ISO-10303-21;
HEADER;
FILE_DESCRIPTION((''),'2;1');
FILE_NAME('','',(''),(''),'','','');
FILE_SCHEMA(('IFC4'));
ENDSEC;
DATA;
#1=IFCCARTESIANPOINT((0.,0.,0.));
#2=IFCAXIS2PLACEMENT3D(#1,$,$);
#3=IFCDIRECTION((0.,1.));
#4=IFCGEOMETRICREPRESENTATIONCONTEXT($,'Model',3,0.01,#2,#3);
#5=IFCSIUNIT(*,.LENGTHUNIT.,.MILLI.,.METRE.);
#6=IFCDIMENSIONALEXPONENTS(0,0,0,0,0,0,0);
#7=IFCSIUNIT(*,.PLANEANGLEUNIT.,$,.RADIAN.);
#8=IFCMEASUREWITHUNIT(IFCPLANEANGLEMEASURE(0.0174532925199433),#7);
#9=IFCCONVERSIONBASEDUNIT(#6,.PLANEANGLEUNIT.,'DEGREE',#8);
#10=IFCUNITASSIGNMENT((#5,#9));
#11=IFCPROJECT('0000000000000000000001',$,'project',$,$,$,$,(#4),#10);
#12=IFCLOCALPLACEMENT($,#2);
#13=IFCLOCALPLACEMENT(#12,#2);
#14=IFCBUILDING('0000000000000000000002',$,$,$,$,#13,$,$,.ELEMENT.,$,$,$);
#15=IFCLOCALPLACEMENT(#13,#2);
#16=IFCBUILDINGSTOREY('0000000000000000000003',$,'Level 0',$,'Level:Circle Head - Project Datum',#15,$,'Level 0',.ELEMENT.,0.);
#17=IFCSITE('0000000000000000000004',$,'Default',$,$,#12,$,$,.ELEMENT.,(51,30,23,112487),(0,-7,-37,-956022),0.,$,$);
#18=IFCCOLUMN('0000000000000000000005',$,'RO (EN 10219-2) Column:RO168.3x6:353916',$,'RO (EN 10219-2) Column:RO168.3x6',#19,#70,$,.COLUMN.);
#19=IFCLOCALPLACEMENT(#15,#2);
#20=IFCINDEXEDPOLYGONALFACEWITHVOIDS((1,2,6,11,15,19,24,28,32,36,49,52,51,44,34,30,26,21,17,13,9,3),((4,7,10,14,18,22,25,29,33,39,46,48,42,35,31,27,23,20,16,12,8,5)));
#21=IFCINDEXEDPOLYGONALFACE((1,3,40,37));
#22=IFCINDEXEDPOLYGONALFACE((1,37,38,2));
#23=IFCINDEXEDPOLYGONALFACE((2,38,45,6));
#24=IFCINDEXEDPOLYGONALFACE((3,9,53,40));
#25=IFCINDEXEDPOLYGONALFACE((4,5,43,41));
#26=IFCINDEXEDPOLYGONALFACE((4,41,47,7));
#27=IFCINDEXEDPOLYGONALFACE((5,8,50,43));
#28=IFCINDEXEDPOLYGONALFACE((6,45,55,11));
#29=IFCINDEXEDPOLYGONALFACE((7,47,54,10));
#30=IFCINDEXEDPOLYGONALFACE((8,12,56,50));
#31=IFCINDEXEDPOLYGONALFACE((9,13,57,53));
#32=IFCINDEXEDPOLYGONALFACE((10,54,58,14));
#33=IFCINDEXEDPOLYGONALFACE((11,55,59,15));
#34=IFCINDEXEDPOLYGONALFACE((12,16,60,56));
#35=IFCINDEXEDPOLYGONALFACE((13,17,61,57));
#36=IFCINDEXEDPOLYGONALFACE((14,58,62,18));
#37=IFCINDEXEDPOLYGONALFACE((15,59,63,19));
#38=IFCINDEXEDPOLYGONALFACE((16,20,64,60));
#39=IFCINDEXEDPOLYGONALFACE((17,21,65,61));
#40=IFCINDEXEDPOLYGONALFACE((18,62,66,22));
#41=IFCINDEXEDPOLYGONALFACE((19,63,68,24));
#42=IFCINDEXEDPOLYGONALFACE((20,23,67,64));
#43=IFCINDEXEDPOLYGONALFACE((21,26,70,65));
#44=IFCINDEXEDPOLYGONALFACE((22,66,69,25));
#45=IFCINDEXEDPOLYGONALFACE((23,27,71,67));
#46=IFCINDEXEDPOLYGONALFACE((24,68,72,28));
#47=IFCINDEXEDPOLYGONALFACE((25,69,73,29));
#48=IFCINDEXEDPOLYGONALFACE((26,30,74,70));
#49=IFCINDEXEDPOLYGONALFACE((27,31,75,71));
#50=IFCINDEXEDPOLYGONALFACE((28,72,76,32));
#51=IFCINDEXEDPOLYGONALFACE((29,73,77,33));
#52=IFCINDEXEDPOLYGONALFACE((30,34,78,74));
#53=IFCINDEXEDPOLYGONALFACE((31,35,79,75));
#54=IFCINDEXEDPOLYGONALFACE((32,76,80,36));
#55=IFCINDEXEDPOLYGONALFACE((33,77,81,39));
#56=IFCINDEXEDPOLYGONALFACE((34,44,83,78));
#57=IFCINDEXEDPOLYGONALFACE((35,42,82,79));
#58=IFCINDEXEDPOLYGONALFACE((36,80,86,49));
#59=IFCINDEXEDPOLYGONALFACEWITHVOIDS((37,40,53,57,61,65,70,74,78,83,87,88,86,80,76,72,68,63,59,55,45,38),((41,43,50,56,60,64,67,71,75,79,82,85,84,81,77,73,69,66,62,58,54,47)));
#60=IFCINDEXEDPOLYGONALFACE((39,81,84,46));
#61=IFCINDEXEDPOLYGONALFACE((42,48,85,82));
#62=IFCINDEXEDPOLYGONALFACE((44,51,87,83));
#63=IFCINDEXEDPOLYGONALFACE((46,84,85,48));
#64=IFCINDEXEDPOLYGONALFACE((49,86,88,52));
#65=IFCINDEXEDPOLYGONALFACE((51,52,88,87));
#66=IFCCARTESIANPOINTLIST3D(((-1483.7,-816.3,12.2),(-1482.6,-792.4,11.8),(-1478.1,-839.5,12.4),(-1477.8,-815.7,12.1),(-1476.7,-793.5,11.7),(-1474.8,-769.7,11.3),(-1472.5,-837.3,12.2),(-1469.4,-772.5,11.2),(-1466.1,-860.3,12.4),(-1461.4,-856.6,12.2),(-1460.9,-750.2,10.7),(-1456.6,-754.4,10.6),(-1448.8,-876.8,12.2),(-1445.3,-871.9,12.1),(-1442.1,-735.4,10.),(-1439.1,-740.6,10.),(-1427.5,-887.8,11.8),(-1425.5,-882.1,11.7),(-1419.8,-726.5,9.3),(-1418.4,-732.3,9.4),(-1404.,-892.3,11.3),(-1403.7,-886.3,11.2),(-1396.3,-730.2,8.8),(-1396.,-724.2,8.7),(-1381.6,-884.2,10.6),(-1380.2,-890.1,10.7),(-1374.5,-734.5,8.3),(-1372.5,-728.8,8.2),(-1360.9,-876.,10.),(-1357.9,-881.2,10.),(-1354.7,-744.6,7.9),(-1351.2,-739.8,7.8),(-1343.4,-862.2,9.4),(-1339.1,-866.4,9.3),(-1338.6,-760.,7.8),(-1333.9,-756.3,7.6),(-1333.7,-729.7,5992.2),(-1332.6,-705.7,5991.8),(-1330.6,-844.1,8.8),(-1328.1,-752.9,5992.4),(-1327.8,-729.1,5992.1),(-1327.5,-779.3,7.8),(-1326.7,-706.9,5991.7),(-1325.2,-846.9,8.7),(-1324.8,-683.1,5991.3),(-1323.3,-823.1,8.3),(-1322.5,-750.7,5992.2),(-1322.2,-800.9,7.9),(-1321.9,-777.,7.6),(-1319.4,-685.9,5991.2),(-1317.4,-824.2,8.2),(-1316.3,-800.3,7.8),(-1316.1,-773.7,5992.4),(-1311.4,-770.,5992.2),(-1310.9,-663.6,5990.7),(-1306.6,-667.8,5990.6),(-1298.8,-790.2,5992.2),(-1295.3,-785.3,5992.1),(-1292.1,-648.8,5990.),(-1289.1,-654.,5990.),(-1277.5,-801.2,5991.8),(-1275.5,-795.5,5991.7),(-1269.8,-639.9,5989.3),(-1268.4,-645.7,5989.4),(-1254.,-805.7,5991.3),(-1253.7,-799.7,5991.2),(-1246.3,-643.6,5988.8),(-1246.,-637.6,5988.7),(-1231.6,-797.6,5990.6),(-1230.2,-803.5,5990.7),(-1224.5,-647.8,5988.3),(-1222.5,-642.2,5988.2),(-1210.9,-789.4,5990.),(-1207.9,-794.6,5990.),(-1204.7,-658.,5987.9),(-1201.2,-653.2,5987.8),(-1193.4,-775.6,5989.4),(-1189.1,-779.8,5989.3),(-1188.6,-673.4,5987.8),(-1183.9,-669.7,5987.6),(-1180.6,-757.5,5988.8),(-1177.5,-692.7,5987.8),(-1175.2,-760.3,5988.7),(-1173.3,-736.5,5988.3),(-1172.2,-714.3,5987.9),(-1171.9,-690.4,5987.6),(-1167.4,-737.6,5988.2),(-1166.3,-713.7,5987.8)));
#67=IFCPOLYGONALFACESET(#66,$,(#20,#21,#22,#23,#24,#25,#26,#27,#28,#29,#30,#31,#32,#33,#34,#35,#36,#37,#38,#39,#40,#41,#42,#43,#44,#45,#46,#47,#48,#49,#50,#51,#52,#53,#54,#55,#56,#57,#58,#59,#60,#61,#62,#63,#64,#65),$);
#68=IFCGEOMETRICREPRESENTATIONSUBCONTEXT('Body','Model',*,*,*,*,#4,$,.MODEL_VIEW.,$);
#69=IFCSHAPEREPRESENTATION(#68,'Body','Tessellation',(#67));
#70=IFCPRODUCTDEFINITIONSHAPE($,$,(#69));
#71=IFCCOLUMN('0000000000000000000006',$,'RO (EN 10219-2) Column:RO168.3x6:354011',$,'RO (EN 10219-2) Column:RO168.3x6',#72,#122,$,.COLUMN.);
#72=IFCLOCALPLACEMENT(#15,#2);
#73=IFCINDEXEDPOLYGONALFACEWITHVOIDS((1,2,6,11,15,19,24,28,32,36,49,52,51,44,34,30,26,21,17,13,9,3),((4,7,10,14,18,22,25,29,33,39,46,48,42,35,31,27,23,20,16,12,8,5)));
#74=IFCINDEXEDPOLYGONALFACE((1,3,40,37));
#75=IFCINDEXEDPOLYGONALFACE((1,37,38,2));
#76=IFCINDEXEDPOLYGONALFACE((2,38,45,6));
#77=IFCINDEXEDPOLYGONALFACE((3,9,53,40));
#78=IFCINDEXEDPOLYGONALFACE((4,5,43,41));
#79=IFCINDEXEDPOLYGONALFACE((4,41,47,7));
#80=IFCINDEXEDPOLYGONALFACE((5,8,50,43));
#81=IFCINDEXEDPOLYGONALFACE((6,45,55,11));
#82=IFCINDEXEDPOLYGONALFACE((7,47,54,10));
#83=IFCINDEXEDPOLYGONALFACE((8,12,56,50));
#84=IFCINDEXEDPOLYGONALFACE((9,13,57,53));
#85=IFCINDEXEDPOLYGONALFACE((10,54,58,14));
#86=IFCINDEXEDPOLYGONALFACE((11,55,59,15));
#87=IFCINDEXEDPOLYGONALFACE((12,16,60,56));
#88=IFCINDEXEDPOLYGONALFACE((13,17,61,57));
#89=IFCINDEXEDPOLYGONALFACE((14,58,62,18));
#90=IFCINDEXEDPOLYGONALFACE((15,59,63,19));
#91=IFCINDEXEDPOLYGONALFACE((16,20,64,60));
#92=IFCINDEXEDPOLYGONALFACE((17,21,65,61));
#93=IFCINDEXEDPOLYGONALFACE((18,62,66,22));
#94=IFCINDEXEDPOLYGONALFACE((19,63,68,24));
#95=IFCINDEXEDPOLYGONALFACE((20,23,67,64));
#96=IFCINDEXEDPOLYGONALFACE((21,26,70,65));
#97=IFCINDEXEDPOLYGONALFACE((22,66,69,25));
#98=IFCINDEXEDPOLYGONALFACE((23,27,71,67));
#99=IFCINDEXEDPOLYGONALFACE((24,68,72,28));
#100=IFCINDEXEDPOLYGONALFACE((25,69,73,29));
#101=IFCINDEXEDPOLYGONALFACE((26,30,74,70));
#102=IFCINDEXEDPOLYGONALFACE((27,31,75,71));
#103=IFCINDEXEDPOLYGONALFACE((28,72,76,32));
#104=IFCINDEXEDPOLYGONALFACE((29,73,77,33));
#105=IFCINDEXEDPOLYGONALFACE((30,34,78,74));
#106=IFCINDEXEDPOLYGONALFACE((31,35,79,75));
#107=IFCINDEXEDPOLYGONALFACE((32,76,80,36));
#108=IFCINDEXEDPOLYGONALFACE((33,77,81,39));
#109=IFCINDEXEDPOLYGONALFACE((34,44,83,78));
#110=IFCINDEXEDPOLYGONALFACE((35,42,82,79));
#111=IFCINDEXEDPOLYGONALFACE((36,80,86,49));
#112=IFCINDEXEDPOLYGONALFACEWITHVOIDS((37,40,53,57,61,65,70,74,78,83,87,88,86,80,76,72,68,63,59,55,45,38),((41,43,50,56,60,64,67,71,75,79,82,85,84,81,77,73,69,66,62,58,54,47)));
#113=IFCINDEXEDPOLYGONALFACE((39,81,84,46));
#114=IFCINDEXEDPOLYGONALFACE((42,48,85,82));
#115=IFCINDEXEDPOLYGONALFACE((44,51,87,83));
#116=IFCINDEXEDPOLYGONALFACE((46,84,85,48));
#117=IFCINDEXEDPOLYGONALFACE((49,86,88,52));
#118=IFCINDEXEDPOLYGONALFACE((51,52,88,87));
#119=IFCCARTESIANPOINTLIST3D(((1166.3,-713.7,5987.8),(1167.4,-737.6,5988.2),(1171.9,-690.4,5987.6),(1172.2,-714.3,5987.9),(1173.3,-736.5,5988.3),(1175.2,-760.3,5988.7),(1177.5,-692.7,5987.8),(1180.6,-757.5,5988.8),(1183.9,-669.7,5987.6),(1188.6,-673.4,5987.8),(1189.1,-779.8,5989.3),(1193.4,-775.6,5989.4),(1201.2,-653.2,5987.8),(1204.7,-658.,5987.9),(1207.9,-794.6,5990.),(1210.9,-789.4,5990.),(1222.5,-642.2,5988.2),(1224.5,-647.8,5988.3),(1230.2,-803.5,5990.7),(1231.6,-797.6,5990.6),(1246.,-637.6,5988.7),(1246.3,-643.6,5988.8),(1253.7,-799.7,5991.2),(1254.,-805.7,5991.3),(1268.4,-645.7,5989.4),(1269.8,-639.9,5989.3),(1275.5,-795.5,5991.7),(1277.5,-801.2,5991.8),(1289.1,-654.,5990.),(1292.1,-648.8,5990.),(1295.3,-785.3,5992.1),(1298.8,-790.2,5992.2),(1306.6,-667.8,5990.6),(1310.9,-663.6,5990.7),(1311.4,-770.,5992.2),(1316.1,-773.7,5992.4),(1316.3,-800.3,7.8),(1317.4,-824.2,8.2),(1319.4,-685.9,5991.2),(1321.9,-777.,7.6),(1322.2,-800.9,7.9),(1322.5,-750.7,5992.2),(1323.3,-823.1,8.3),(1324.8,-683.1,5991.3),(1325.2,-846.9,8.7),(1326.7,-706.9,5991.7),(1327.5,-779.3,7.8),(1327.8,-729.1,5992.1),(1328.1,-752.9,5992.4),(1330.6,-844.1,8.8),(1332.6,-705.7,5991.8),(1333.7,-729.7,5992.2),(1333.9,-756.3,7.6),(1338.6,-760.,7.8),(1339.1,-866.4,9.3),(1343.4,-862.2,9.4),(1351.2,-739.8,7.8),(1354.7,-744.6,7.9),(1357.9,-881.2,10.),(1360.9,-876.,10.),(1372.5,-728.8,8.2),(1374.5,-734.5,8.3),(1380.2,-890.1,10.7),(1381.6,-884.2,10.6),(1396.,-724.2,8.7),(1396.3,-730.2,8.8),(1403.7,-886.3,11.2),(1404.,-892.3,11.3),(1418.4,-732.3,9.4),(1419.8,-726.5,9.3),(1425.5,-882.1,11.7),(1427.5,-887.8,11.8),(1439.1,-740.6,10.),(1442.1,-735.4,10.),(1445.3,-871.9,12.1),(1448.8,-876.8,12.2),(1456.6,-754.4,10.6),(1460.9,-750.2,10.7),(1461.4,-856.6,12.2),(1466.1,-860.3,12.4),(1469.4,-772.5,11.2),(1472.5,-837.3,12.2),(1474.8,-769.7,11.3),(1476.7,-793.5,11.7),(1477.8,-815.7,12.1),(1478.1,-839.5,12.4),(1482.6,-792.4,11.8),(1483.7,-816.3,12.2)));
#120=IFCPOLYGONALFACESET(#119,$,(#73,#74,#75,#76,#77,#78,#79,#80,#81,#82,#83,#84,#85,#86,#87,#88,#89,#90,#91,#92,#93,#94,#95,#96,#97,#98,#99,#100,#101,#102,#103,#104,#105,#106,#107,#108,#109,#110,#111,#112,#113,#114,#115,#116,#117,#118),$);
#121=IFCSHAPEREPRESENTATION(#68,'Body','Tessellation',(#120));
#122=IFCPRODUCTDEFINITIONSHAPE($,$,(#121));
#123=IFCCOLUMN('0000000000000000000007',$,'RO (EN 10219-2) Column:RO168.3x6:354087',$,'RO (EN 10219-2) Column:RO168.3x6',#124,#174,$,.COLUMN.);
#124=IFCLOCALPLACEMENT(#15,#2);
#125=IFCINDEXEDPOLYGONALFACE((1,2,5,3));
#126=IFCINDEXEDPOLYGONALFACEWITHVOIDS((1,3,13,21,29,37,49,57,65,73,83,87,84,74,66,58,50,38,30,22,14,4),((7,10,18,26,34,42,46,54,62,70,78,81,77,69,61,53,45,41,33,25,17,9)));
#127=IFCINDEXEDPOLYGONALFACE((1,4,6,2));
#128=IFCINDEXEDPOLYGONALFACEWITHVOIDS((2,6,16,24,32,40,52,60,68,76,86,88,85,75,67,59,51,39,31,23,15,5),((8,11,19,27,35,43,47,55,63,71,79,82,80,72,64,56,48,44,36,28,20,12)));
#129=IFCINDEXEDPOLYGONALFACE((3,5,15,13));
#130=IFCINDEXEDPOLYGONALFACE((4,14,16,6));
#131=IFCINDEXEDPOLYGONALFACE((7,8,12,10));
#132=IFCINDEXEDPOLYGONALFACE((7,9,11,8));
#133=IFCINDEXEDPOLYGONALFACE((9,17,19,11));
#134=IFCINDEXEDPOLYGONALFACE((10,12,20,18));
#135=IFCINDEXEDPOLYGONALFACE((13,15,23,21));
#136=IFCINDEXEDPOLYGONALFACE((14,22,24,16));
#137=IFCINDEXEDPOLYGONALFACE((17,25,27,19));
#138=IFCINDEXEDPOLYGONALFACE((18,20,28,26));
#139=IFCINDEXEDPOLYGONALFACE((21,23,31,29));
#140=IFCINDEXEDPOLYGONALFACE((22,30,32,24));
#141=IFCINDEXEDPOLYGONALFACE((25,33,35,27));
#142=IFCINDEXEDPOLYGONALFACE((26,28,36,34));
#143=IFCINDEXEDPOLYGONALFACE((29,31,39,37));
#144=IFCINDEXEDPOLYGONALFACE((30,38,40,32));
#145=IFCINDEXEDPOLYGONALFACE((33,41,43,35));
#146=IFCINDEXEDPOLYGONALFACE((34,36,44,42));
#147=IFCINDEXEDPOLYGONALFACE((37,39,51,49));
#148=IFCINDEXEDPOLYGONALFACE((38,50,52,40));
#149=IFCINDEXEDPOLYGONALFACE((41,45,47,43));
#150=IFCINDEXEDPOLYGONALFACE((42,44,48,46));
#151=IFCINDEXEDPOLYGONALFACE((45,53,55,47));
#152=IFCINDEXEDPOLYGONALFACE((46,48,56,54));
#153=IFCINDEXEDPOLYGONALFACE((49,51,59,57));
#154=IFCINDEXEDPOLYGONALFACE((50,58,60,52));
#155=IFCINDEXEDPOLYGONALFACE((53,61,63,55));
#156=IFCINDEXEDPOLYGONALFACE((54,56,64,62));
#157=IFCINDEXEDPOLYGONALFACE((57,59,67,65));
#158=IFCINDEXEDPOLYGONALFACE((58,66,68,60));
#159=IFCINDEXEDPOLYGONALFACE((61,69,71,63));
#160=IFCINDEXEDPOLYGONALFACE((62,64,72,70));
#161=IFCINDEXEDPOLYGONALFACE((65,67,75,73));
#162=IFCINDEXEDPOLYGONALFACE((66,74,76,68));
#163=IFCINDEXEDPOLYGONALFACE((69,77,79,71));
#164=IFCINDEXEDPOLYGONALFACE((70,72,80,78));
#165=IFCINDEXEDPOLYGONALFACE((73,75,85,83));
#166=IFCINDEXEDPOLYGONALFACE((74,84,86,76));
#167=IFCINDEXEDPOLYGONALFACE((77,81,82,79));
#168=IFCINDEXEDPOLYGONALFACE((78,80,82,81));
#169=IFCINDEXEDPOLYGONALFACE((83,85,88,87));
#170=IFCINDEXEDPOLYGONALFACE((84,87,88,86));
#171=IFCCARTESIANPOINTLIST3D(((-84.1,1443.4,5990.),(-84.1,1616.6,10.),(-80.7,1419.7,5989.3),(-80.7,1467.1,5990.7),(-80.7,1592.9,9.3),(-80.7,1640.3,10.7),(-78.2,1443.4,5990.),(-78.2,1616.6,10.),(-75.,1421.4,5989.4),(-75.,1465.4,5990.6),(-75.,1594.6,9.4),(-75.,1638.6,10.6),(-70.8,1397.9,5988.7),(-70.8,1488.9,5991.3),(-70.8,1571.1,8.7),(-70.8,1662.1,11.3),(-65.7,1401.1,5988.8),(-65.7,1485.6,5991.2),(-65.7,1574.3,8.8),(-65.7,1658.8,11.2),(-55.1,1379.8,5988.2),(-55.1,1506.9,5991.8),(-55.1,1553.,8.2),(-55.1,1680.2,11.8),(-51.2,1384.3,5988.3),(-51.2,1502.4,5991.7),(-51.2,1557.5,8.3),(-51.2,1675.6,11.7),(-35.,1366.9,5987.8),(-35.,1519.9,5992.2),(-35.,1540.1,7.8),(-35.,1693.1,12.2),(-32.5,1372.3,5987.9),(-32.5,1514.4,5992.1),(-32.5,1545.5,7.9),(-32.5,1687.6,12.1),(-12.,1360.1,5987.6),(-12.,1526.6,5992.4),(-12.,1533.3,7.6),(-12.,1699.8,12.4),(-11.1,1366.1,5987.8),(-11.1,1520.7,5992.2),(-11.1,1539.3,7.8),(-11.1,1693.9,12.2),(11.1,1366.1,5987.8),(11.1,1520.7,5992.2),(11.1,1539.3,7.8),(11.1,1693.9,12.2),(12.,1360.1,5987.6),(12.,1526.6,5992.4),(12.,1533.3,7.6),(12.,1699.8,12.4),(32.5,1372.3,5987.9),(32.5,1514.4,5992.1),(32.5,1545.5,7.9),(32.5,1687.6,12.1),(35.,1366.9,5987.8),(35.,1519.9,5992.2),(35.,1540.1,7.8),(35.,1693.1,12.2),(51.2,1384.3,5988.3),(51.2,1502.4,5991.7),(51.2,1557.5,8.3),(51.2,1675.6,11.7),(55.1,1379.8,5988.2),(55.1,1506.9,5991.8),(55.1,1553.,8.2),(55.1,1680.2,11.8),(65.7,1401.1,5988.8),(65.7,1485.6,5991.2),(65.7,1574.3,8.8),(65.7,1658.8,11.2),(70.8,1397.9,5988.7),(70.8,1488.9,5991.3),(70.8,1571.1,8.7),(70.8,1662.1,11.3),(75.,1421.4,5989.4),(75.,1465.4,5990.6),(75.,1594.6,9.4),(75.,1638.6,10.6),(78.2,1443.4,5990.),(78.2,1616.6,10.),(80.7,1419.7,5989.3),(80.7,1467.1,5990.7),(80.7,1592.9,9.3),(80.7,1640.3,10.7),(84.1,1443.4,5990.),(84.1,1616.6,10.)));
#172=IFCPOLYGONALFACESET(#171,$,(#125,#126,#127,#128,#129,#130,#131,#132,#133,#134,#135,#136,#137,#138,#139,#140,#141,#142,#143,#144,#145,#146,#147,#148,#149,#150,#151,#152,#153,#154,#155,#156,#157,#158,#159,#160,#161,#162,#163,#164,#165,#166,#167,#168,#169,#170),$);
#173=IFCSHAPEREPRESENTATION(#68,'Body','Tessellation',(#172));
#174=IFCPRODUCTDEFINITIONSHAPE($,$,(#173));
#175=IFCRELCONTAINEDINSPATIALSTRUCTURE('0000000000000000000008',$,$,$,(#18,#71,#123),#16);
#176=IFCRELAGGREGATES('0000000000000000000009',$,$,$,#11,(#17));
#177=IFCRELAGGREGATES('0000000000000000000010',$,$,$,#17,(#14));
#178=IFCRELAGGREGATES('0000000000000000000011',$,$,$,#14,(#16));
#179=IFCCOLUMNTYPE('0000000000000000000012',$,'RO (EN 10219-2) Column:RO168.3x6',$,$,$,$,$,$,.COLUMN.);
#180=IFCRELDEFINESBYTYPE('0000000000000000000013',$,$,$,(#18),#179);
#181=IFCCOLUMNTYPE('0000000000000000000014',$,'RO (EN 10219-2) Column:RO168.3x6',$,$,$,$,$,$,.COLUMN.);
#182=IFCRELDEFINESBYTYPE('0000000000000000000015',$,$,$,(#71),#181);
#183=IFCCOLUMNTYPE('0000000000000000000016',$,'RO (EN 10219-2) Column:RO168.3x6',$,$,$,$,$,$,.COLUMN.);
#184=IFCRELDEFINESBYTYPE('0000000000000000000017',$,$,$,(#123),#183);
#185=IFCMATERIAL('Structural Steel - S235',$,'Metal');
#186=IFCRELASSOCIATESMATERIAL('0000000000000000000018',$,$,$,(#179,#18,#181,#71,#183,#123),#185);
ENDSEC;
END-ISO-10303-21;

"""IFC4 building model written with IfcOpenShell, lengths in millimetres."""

from ifc_helpers import new_model, entity, si_unit, converted_unit, direction, frame, origin, place, context, subcontext, project, spatial, arc, indexed_curve, outline, extrude, source, transform, mapped, material, type_object, type_shapes, element, save


model = new_model("IFC4")

# Units and contexts
model_context = context("Model", 3, precision=0.01, world=origin(), true_north=direction((0.0, 1.0)))
body_context = subcontext(model_context, "Body", "Model", "MODEL_VIEW")
ifc_project = project(units=[si_unit("LENGTHUNIT", "METRE", prefix="MILLI"), converted_unit("PLANEANGLEUNIT", "DEGREE", entity("IfcPlaneAngleMeasure", 0.0174532925199433), si_unit("PLANEANGLEUNIT", "RADIAN"), dimensions=[0, 0, 0, 0, 0, 0, 0])], contexts=[model_context])

# Site, building, storey
site_placement = place(None, origin())
site = spatial("IfcSite", under=ifc_project, at=site_placement, Name="Default", CompositionType="ELEMENT", RefLatitude=(51, 30, 23, 112487), RefLongitude=(0, -7, -37, -956022), RefElevation=0.0)
building_placement = place(site_placement, origin())
building = spatial("IfcBuilding", under=site, at=building_placement, CompositionType="ELEMENT")
storey_placement = place(building_placement, origin())
storey = spatial("IfcBuildingStorey", under=building, at=storey_placement, Name="Level 0", ObjectType="Level:Circle Head - Project Datum", LongName="Level 0", CompositionType="ELEMENT", Elevation=0.0)

# Columns
ifc_material_1 = material(Name="Structural Steel - S235", Category="Metal")
column_type_1 = type_object("IfcColumnType", Name="RO (EN 10219-2) Column:RO168.3x6", PredefinedType="COLUMN", material=ifc_material_1)
shared_shape_1 = source(origin(), body_context, "Body", "SweptSolid", [
    extrude(outline(indexed_curve([(-84.2, 0.0), (0.0, -84.1), (84.1, 0.0), (0.0, 84.1)], segments=[arc(1, 2, 3), arc(3, 4, 1)], self_intersect=False), holes=[indexed_curve([(-78.2, 0.0), (0.0, 78.2), (78.2, 0.0), (0.0, -78.2)], segments=[arc(1, 2, 3), arc(3, 4, 1)], self_intersect=False)]), frame((-1400.0, -808.3, 10.0), z_axis=(0.025073, 0.014476, 0.999581), x_axis=(-0.5, 0.866025, 0.0)), (0.0, 0.0, 1.0), 5982.5),
])
type_shapes(column_type_1, [shared_shape_1])
column_1_placement = place(storey_placement, origin())
element("IfcColumn", 1, at=column_1_placement, inside=storey, type_object=column_type_1, material=ifc_material_1, Name="RO (EN 10219-2) Column:RO168.3x6:353916", ObjectType="RO (EN 10219-2) Column:RO168.3x6", PredefinedType="COLUMN", context=body_context, shape_type="MappedRepresentation", body=[
    mapped(shared_shape_1, transform((0.0, 0.0, 0.0), scale=1.0)),
])
column_type_2 = type_object("IfcColumnType", Name="RO (EN 10219-2) Column:RO168.3x6", PredefinedType="COLUMN", material=ifc_material_1)
shared_shape_2 = source(origin(), body_context, "Body", "SweptSolid", [
    extrude(outline(indexed_curve([(-84.2, 0.0), (0.0, -84.1), (84.2, 0.0), (0.0, 84.1)], segments=[arc(1, 2, 3), arc(3, 4, 1)], self_intersect=False), holes=[indexed_curve([(-78.2, 0.0), (0.0, 78.2), (78.2, 0.0), (0.0, -78.2)], segments=[arc(1, 2, 3), arc(3, 4, 1)], self_intersect=False)]), frame((1250.0, -721.7, 5990.0), z_axis=(0.025073, -0.014476, -0.999581), x_axis=(-0.5, -0.866025, 0.0)), (0.0, 0.0, 1.0), 5982.5),
])
type_shapes(column_type_2, [shared_shape_2])
column_2_placement = place(storey_placement, origin())
element("IfcColumn", 2, at=column_2_placement, inside=storey, type_object=column_type_2, material=ifc_material_1, Name="RO (EN 10219-2) Column:RO168.3x6:354011", ObjectType="RO (EN 10219-2) Column:RO168.3x6", PredefinedType="COLUMN", context=body_context, shape_type="MappedRepresentation", body=[
    mapped(shared_shape_2, transform((0.0, 0.0, 0.0), scale=1.0)),
])
column_type_3 = type_object("IfcColumnType", Name="RO (EN 10219-2) Column:RO168.3x6", PredefinedType="COLUMN", material=ifc_material_1)
shared_shape_3 = source(origin(), body_context, "Body", "SweptSolid", [
    extrude(outline(indexed_curve([(-84.1, 0.0), (0.0, -84.1), (84.1, 0.0), (0.0, 84.1)], segments=[arc(1, 2, 3), arc(3, 4, 1)], self_intersect=False), holes=[indexed_curve([(-78.2, 0.0), (0.0, 78.2), (78.2, 0.0), (0.0, -78.2)], segments=[arc(1, 2, 3), arc(3, 4, 1)], self_intersect=False)]), frame((0.0, 1443.4, 5990.0), z_axis=(0.0, 0.028952, -0.999581), x_axis=(1.0, 0.0, 0.0)), (0.0, 0.0, 1.0), 5982.5),
])
type_shapes(column_type_3, [shared_shape_3])
column_3_placement = place(storey_placement, origin())
element("IfcColumn", 3, at=column_3_placement, inside=storey, type_object=column_type_3, material=ifc_material_1, Name="RO (EN 10219-2) Column:RO168.3x6:354087", ObjectType="RO (EN 10219-2) Column:RO168.3x6", PredefinedType="COLUMN", context=body_context, shape_type="MappedRepresentation", body=[
    mapped(shared_shape_3, transform((0.0, 0.0, 0.0), scale=1.0)),
])

save(model, "model.ifc")
